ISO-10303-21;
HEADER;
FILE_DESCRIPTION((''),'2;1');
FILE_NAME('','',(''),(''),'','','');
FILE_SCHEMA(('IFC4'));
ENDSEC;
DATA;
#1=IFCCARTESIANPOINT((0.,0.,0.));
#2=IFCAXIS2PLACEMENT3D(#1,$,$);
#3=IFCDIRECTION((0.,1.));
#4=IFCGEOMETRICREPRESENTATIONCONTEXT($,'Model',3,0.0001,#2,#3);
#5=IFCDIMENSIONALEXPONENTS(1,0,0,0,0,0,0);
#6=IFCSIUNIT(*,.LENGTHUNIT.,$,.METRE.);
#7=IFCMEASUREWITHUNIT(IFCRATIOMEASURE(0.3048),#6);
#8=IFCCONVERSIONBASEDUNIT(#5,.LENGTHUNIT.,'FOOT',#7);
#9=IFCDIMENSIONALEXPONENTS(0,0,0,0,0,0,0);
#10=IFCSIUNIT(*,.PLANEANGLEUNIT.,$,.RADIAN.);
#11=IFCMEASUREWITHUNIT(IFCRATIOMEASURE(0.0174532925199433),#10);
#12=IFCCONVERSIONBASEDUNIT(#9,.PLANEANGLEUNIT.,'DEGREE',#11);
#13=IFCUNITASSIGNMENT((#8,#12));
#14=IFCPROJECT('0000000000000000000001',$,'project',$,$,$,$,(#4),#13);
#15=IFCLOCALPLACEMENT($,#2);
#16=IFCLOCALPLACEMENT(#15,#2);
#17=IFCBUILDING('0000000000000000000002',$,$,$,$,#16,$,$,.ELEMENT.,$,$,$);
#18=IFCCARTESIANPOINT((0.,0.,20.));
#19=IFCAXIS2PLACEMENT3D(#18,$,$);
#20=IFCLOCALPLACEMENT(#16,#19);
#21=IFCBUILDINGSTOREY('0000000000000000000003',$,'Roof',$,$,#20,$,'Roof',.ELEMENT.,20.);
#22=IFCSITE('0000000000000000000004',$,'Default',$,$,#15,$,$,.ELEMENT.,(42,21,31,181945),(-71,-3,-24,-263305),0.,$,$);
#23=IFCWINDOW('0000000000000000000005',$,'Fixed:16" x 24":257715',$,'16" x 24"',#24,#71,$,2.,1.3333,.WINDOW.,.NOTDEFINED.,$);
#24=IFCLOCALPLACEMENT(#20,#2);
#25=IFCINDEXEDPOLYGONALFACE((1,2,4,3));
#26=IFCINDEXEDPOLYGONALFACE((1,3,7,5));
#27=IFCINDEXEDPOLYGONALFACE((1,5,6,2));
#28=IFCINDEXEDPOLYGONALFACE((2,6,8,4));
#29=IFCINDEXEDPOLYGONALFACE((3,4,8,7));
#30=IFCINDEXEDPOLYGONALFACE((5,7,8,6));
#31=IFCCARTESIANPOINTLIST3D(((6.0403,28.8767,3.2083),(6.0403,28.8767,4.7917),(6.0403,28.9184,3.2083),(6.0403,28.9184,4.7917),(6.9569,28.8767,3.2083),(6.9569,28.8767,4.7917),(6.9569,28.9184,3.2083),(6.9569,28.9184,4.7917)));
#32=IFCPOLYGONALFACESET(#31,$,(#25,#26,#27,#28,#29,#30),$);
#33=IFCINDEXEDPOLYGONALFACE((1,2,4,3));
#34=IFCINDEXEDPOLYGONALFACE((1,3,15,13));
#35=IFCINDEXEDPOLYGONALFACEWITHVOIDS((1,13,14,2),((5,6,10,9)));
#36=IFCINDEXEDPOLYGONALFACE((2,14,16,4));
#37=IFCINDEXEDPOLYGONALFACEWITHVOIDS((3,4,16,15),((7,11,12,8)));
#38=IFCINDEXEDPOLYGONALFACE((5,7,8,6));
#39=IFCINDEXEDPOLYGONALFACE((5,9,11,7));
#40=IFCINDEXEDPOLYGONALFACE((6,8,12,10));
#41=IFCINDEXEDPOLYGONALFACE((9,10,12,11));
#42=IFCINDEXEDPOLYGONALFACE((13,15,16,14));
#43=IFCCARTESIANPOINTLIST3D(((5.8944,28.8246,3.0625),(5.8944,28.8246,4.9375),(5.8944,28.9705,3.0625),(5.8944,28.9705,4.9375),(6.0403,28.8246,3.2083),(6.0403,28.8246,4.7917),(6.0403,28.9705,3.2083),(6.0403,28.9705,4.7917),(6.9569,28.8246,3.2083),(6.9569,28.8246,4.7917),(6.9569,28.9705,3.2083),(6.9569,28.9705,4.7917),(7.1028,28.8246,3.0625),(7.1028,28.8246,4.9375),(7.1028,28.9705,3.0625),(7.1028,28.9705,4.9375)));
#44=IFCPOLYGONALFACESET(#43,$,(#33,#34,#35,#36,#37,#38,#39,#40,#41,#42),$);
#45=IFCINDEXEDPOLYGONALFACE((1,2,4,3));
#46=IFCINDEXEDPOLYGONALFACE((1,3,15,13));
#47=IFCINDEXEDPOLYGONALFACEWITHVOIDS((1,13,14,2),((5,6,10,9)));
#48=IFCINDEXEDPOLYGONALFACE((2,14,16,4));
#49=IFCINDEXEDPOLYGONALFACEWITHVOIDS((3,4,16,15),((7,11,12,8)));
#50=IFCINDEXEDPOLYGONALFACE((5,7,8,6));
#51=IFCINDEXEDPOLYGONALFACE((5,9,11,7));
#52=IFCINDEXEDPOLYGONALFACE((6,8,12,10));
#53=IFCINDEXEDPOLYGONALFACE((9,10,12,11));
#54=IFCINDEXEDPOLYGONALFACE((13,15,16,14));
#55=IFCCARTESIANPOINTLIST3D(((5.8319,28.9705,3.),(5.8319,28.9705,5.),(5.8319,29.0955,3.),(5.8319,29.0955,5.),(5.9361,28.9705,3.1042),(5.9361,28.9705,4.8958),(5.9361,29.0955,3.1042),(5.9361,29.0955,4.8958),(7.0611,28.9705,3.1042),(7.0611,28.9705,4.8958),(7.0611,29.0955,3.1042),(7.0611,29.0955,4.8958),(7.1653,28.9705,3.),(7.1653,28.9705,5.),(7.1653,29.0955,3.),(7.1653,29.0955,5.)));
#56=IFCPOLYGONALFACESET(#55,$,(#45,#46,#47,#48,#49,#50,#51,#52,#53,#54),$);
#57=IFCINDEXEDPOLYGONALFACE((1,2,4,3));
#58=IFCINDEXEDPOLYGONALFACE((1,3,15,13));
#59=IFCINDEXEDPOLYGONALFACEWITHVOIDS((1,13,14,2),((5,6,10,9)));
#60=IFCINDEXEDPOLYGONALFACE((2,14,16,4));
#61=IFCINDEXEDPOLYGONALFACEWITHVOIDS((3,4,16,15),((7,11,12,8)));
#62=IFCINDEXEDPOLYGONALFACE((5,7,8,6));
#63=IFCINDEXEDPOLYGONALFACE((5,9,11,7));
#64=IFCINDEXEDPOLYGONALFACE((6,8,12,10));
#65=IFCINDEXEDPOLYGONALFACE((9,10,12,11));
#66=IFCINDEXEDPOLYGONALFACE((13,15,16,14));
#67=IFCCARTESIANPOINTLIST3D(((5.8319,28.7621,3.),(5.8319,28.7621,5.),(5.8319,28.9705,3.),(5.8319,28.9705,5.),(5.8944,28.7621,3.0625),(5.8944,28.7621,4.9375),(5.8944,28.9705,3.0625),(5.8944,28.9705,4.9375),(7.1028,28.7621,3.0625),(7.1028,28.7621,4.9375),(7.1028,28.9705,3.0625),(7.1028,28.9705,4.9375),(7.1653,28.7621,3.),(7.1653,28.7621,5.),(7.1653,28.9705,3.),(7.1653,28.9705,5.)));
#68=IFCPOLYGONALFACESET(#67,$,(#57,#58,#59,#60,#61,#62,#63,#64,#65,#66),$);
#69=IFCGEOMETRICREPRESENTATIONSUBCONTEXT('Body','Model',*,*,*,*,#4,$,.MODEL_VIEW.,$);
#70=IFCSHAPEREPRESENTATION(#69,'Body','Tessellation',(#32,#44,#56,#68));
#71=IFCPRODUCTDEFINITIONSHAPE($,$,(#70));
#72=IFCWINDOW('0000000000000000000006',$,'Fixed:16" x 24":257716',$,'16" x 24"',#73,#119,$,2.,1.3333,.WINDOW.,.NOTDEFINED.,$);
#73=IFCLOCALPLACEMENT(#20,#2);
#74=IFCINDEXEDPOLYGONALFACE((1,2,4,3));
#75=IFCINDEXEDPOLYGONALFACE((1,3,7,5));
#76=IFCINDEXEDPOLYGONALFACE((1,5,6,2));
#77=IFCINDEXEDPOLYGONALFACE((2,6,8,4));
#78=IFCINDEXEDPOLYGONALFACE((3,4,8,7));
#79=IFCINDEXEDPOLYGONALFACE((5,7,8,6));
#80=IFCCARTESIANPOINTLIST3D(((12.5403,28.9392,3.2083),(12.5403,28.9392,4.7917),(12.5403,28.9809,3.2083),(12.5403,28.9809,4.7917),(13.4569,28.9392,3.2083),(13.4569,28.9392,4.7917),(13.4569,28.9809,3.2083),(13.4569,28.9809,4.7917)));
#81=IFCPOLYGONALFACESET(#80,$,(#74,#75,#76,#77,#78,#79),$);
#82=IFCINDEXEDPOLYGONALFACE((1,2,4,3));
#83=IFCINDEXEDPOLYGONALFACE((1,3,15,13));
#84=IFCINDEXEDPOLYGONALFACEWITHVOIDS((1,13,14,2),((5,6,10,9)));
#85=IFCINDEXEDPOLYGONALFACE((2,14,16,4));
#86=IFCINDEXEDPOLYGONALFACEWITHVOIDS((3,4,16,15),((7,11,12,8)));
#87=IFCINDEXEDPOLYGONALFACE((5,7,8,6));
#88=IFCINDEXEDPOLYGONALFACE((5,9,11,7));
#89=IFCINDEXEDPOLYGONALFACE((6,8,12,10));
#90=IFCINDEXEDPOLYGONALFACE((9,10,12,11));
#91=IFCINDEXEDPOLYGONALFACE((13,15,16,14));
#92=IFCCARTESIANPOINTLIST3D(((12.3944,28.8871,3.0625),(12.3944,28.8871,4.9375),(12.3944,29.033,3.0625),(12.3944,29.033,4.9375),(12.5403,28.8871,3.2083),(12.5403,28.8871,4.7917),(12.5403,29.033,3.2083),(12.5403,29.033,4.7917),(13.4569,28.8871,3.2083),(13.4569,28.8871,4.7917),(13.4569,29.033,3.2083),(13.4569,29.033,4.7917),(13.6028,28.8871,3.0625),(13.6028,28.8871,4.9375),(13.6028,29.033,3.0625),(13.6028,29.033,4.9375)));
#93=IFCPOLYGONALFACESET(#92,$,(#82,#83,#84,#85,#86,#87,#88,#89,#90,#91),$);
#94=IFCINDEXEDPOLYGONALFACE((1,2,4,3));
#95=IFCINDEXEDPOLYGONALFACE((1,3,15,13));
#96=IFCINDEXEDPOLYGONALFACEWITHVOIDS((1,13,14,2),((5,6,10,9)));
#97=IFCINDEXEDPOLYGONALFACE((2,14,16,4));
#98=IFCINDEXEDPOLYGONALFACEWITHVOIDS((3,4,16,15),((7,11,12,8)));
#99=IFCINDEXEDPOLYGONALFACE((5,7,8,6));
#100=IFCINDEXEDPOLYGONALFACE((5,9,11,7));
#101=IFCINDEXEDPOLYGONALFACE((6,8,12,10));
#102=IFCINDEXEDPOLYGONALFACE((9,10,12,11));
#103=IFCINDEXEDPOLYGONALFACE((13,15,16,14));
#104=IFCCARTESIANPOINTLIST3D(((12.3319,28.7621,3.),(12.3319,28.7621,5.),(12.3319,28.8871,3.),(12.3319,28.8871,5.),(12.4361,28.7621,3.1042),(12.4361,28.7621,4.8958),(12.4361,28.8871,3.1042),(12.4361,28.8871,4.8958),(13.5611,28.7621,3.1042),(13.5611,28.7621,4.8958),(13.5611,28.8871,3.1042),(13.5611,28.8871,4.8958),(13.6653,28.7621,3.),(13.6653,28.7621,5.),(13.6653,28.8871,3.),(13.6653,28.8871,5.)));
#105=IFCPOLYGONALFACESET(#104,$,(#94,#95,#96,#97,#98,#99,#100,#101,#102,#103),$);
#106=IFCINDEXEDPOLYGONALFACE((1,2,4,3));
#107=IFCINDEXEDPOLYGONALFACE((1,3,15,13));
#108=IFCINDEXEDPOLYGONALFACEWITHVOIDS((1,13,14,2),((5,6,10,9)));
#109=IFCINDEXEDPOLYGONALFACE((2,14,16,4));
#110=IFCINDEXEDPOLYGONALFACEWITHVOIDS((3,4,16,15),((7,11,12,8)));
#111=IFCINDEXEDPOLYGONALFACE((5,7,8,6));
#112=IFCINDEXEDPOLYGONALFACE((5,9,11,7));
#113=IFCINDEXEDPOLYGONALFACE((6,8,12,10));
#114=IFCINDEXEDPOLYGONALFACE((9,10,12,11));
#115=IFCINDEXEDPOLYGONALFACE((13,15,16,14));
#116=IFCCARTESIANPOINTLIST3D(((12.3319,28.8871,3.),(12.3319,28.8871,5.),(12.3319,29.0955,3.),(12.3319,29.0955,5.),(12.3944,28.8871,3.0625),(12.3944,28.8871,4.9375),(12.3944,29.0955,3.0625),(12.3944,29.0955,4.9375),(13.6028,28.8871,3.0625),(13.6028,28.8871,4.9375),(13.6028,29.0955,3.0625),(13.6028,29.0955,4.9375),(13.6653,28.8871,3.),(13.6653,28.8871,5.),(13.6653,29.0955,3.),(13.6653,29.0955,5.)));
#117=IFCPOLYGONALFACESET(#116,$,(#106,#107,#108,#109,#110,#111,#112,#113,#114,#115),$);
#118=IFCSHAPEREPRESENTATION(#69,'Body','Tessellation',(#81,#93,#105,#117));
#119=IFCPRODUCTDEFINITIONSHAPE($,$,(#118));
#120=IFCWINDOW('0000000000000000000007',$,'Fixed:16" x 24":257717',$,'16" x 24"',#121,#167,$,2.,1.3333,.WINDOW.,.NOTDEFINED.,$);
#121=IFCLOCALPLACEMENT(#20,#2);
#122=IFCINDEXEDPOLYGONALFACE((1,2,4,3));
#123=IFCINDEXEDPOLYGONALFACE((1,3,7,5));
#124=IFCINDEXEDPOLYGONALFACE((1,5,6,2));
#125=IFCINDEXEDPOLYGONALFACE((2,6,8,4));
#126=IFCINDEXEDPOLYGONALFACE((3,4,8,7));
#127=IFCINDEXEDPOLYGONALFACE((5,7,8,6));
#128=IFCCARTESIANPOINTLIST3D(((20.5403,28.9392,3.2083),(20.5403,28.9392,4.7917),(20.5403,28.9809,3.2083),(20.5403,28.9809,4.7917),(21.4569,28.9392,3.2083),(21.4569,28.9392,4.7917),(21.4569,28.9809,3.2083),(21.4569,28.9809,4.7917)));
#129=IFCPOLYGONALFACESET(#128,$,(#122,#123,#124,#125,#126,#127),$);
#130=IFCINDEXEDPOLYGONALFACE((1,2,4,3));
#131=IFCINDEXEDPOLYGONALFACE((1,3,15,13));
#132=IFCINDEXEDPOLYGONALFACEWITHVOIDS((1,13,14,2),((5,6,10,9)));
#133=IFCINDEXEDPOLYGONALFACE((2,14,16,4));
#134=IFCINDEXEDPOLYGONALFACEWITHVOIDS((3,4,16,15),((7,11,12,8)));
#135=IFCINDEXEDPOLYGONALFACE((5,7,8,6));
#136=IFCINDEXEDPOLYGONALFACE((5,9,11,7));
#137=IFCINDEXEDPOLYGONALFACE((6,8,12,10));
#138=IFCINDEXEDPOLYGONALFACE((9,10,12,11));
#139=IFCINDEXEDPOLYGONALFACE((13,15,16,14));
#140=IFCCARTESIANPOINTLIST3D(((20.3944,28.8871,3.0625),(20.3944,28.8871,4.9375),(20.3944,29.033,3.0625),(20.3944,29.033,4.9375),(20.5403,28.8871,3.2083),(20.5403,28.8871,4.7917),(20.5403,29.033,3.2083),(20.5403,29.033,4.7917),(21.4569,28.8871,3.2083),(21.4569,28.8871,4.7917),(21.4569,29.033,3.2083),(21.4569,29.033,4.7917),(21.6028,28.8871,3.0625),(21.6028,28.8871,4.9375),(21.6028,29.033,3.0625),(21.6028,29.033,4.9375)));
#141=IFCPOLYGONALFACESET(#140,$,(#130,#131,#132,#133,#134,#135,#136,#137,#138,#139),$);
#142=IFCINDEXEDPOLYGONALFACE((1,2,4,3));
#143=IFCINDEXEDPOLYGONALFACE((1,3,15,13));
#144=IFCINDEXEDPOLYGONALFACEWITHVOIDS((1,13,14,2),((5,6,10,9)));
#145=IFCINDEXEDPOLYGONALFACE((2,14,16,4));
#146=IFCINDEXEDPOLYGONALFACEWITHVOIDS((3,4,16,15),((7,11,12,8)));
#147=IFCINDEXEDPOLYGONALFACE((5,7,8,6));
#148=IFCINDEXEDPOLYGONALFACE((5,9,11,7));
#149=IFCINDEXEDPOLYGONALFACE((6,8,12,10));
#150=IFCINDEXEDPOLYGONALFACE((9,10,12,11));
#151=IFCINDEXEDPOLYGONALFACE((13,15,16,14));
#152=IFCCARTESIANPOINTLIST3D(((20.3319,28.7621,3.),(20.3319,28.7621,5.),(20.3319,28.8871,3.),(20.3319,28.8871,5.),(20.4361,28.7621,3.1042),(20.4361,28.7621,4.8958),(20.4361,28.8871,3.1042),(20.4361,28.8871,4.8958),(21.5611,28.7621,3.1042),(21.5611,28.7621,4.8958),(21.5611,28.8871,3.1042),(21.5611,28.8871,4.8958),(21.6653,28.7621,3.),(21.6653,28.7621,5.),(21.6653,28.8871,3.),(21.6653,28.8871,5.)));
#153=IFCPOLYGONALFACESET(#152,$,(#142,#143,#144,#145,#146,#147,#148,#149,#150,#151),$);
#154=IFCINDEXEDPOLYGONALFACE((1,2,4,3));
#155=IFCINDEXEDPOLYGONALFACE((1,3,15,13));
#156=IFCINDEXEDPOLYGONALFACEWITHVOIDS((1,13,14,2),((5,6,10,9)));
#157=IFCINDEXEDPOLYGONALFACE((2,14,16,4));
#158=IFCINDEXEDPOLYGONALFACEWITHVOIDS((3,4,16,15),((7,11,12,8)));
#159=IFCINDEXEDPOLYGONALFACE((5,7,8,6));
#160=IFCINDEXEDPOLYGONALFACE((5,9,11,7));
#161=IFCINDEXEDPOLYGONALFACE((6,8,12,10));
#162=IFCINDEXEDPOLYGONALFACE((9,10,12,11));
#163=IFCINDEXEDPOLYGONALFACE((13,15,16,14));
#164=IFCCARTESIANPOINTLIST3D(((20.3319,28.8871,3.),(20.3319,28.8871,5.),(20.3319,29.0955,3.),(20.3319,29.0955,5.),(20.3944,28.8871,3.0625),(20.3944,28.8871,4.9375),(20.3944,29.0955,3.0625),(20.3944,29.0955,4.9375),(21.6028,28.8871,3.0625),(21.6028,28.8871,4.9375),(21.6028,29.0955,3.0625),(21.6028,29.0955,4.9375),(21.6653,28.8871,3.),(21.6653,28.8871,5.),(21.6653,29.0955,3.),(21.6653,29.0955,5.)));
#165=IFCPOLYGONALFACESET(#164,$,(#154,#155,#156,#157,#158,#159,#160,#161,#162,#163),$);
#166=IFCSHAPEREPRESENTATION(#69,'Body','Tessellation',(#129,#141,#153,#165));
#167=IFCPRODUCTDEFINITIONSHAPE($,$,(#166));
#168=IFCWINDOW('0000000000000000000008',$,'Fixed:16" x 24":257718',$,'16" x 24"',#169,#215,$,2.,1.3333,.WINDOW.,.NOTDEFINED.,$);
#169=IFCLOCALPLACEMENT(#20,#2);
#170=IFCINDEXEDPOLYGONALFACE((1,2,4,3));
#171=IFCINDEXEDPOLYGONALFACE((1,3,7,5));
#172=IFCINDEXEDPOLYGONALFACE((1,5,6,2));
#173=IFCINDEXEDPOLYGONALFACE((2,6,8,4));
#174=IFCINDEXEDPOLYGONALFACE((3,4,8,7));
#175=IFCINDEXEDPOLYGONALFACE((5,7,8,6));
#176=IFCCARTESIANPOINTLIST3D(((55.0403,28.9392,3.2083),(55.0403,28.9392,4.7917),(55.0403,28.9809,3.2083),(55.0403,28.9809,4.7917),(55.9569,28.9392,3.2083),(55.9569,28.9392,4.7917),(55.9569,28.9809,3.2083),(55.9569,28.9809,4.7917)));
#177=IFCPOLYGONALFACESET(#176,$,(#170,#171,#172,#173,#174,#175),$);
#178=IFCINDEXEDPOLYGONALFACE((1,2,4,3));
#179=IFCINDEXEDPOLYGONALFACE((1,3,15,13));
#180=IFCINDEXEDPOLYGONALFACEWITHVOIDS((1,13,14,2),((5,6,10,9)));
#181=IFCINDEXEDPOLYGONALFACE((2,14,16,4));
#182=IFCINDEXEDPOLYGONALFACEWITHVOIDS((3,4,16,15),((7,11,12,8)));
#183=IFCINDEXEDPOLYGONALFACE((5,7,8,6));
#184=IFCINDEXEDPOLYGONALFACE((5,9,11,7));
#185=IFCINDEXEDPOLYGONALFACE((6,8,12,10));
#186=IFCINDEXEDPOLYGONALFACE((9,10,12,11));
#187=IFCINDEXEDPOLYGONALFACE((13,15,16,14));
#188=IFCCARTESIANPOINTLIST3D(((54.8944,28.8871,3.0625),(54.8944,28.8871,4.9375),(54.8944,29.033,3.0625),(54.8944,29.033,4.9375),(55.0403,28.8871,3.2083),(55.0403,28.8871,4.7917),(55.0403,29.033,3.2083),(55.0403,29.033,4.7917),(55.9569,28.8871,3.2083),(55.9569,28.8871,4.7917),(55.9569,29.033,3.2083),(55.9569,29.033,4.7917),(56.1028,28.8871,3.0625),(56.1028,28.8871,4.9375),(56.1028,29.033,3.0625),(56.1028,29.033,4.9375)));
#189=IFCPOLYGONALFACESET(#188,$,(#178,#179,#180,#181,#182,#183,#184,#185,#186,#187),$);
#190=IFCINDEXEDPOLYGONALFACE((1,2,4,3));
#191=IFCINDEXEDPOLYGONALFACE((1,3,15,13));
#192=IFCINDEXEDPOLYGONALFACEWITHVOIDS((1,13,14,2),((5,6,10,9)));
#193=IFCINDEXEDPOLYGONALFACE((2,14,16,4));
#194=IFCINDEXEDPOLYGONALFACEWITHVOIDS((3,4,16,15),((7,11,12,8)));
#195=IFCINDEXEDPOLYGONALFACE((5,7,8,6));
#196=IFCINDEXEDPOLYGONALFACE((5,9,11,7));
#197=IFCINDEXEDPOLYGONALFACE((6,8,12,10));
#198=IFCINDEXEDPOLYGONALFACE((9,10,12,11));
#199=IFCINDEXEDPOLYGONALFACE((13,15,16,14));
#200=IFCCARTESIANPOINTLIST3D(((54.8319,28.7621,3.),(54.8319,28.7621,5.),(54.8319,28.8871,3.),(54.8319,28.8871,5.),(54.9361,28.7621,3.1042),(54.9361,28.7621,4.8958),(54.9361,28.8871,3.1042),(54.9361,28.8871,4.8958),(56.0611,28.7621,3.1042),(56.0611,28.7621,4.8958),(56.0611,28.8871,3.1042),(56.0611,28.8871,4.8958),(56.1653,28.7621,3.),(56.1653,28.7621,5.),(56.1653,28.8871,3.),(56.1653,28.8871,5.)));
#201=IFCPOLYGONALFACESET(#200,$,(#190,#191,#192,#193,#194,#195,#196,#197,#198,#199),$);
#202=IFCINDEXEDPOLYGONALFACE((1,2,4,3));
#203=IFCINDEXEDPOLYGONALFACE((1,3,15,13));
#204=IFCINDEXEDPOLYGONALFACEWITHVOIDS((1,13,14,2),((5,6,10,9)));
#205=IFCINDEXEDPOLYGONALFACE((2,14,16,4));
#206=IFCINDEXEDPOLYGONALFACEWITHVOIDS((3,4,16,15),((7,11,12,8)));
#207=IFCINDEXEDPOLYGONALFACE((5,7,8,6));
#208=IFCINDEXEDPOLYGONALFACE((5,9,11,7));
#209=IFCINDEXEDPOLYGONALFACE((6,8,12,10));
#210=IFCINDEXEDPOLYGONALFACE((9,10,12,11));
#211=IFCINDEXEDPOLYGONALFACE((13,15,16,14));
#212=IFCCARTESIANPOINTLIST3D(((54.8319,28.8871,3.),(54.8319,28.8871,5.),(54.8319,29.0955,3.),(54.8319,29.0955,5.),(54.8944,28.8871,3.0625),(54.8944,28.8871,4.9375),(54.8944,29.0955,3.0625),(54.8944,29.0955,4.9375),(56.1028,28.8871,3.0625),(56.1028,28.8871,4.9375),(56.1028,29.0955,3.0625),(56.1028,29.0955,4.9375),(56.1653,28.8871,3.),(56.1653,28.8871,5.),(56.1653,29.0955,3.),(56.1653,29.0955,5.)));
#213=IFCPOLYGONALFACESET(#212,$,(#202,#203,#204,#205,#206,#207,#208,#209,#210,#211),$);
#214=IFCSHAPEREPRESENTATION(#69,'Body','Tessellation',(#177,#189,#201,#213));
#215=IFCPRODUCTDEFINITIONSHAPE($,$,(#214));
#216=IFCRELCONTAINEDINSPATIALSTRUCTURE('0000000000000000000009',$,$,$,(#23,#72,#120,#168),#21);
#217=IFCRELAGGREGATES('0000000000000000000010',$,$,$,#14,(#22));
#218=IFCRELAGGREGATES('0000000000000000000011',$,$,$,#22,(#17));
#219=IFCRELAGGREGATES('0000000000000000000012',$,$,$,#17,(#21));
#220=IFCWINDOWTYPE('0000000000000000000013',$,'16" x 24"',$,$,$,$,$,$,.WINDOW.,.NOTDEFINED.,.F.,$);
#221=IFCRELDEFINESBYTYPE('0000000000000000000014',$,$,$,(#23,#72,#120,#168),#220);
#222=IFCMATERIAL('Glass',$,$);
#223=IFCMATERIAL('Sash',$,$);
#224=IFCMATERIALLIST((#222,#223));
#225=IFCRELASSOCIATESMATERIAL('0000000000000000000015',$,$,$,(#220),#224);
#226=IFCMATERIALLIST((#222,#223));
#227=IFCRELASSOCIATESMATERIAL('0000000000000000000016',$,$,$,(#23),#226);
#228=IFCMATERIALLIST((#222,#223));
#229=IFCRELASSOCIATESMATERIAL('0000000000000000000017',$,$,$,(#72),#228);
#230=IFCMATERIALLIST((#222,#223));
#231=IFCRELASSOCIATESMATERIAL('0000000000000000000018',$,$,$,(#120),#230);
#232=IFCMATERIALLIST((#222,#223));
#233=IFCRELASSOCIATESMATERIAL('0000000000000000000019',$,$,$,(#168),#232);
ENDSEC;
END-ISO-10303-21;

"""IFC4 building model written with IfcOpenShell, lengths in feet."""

from ifc_helpers import new_model, entity, si_unit, converted_unit, direction, frame, origin, origin_2d_with_axis, place, context, subcontext, project, spatial, polyline, rectangle, outline, extrude, source, transform, mapped, material, material_list, type_object, type_shapes, element, save


model = new_model("IFC4")

# Units and contexts
model_context = context("Model", 3, precision=0.0001, world=origin(), true_north=direction((0.0, 1.0)))
body_context = subcontext(model_context, "Body", "Model", "MODEL_VIEW")
ifc_project = project(units=[converted_unit("LENGTHUNIT", "FOOT", entity("IfcRatioMeasure", 0.3048), si_unit("LENGTHUNIT", "METRE"), dimensions=[1, 0, 0, 0, 0, 0, 0]), converted_unit("PLANEANGLEUNIT", "DEGREE", entity("IfcRatioMeasure", 0.0174532925199433), si_unit("PLANEANGLEUNIT", "RADIAN"), dimensions=[0, 0, 0, 0, 0, 0, 0])], contexts=[model_context])

# Site, building, storey
site_placement = place(None, origin())
site = spatial("IfcSite", under=ifc_project, at=site_placement, Name="Default", CompositionType="ELEMENT", RefLatitude=(42, 21, 31, 181945), RefLongitude=(-71, -3, -24, -263305), RefElevation=0.0)
building_placement = place(site_placement, origin())
building = spatial("IfcBuilding", under=site, at=building_placement, CompositionType="ELEMENT")
storey_placement = place(building_placement, frame((0.0, 0.0, 20.0)))
storey = spatial("IfcBuildingStorey", under=building, at=storey_placement, Name="Roof", LongName="Roof", CompositionType="ELEMENT", Elevation=20.0)

# Windows
ifc_material_1 = material(Name="Glass")
ifc_material_2 = material(Name="Sash")
ifc_material_list_1 = material_list([ifc_material_1, ifc_material_2])
ifc_material_list_2 = material_list([ifc_material_1, ifc_material_2])
window_type = type_object("IfcWindowType", Name="16\" x 24\"", ParameterTakesPrecedence=False, PartitioningType="NOTDEFINED", PredefinedType="WINDOW", material=ifc_material_list_2)
shared_shape_1 = source(origin(), body_context, "Body", "SweptSolid", [
    extrude(rectangle(XDim=0.0417, YDim=0.9167, at=origin_2d_with_axis()), frame((0.6667, 0.1979, 0.2083), z_axis=(0.0, 0.0, 1.0), x_axis=(0.0, 1.0, 0.0)), (0.0, 0.0, 1.0), 1.5833),
    extrude(outline(polyline([(-0.6042, -0.9375), (0.6042, -0.9375), (0.6042, 0.9375), (-0.6042, 0.9375), (-0.6042, -0.9375)]), holes=[polyline([(-0.4583, -0.7917), (-0.4583, 0.7917), (0.4583, 0.7917), (0.4583, -0.7917), (-0.4583, -0.7917)])]), frame((0.6667, 0.125, 1.0), z_axis=(0.0, 1.0, 0.0), x_axis=(1.0, 0.0, 0.0)), (0.0, 0.0, 1.0), 0.1458),
    extrude(outline(polyline([(-0.6667, -1.0), (0.6667, -1.0), (0.6667, 1.0), (-0.6667, 1.0), (-0.6667, -1.0)]), holes=[polyline([(-0.5625, -0.8958), (-0.5625, 0.8958), (0.5625, 0.8958), (0.5625, -0.8958), (-0.5625, -0.8958)])]), frame((0.6667, 0.0, 1.0), z_axis=(0.0, 1.0, 0.0), x_axis=(1.0, 0.0, 0.0)), (0.0, 0.0, 1.0), 0.125),
    extrude(outline(polyline([(-1.0, -0.6667), (1.0, -0.6667), (1.0, 0.6667), (-1.0, 0.6667), (-1.0, -0.6667)]), holes=[polyline([(-0.9375, -0.6042), (-0.9375, 0.6042), (0.9375, 0.6042), (0.9375, -0.6042), (-0.9375, -0.6042)])]), frame((0.6667, 0.125, 1.0), z_axis=(0.0, 1.0, 0.0), x_axis=(0.0, 0.0, -1.0)), (0.0, 0.0, 1.0), 0.2083),
])
type_shapes(window_type, [shared_shape_1])
placement_1 = place(building_placement, frame((0.0, 0.0, 10.0)))
placement_2 = place(placement_1, frame((-0.1681, 28.9288, 0.0)))
placement_3 = place(placement_2, frame((7.3333, 0.1667, 13.0)))
window_1_placement = place(placement_3, frame((0.0, 0.0, 0.0), z_axis=(0.0, 0.0, 1.0), x_axis=(-1.0, 0.0, 0.0)))
element("IfcWindow", 1, at=window_1_placement, inside=storey, type_object=window_type, material=ifc_material_list_1, Name="Fixed:16\" x 24\":257715", ObjectType="16\" x 24\"", OverallHeight=2.0, OverallWidth=1.3333, PartitioningType="NOTDEFINED", PredefinedType="WINDOW", context=body_context, shape_type="MappedRepresentation", body=[
    mapped(shared_shape_1, transform((0.0, 0.0, 0.0), scale=1.0)),
])
ifc_material_list_3 = material_list([ifc_material_1, ifc_material_2])
placement_4 = place(placement_2, frame((12.5, -0.1667, 13.0)))
window_2_placement = place(placement_4, origin())
element("IfcWindow", 2, at=window_2_placement, inside=storey, type_object=window_type, material=ifc_material_list_3, Name="Fixed:16\" x 24\":257716", ObjectType="16\" x 24\"", OverallHeight=2.0, OverallWidth=1.3333, PartitioningType="NOTDEFINED", PredefinedType="WINDOW", context=body_context, shape_type="MappedRepresentation", body=[
    mapped(shared_shape_1, transform((0.0, 0.0, 0.0), scale=1.0)),
])
ifc_material_list_4 = material_list([ifc_material_1, ifc_material_2])
placement_5 = place(placement_2, frame((20.5, -0.1667, 13.0)))
window_3_placement = place(placement_5, origin())
element("IfcWindow", 3, at=window_3_placement, inside=storey, type_object=window_type, material=ifc_material_list_4, Name="Fixed:16\" x 24\":257717", ObjectType="16\" x 24\"", OverallHeight=2.0, OverallWidth=1.3333, PartitioningType="NOTDEFINED", PredefinedType="WINDOW", context=body_context, shape_type="MappedRepresentation", body=[
    mapped(shared_shape_1, transform((0.0, 0.0, 0.0), scale=1.0)),
])
ifc_material_list_5 = material_list([ifc_material_1, ifc_material_2])
placement_6 = place(placement_2, frame((55.0, -0.1667, 13.0)))
window_4_placement = place(placement_6, origin())
element("IfcWindow", 4, at=window_4_placement, inside=storey, type_object=window_type, material=ifc_material_list_5, Name="Fixed:16\" x 24\":257718", ObjectType="16\" x 24\"", OverallHeight=2.0, OverallWidth=1.3333, PartitioningType="NOTDEFINED", PredefinedType="WINDOW", context=body_context, shape_type="MappedRepresentation", body=[
    mapped(shared_shape_1, transform((0.0, 0.0, 0.0), scale=1.0)),
])

save(model, "model.ifc")
